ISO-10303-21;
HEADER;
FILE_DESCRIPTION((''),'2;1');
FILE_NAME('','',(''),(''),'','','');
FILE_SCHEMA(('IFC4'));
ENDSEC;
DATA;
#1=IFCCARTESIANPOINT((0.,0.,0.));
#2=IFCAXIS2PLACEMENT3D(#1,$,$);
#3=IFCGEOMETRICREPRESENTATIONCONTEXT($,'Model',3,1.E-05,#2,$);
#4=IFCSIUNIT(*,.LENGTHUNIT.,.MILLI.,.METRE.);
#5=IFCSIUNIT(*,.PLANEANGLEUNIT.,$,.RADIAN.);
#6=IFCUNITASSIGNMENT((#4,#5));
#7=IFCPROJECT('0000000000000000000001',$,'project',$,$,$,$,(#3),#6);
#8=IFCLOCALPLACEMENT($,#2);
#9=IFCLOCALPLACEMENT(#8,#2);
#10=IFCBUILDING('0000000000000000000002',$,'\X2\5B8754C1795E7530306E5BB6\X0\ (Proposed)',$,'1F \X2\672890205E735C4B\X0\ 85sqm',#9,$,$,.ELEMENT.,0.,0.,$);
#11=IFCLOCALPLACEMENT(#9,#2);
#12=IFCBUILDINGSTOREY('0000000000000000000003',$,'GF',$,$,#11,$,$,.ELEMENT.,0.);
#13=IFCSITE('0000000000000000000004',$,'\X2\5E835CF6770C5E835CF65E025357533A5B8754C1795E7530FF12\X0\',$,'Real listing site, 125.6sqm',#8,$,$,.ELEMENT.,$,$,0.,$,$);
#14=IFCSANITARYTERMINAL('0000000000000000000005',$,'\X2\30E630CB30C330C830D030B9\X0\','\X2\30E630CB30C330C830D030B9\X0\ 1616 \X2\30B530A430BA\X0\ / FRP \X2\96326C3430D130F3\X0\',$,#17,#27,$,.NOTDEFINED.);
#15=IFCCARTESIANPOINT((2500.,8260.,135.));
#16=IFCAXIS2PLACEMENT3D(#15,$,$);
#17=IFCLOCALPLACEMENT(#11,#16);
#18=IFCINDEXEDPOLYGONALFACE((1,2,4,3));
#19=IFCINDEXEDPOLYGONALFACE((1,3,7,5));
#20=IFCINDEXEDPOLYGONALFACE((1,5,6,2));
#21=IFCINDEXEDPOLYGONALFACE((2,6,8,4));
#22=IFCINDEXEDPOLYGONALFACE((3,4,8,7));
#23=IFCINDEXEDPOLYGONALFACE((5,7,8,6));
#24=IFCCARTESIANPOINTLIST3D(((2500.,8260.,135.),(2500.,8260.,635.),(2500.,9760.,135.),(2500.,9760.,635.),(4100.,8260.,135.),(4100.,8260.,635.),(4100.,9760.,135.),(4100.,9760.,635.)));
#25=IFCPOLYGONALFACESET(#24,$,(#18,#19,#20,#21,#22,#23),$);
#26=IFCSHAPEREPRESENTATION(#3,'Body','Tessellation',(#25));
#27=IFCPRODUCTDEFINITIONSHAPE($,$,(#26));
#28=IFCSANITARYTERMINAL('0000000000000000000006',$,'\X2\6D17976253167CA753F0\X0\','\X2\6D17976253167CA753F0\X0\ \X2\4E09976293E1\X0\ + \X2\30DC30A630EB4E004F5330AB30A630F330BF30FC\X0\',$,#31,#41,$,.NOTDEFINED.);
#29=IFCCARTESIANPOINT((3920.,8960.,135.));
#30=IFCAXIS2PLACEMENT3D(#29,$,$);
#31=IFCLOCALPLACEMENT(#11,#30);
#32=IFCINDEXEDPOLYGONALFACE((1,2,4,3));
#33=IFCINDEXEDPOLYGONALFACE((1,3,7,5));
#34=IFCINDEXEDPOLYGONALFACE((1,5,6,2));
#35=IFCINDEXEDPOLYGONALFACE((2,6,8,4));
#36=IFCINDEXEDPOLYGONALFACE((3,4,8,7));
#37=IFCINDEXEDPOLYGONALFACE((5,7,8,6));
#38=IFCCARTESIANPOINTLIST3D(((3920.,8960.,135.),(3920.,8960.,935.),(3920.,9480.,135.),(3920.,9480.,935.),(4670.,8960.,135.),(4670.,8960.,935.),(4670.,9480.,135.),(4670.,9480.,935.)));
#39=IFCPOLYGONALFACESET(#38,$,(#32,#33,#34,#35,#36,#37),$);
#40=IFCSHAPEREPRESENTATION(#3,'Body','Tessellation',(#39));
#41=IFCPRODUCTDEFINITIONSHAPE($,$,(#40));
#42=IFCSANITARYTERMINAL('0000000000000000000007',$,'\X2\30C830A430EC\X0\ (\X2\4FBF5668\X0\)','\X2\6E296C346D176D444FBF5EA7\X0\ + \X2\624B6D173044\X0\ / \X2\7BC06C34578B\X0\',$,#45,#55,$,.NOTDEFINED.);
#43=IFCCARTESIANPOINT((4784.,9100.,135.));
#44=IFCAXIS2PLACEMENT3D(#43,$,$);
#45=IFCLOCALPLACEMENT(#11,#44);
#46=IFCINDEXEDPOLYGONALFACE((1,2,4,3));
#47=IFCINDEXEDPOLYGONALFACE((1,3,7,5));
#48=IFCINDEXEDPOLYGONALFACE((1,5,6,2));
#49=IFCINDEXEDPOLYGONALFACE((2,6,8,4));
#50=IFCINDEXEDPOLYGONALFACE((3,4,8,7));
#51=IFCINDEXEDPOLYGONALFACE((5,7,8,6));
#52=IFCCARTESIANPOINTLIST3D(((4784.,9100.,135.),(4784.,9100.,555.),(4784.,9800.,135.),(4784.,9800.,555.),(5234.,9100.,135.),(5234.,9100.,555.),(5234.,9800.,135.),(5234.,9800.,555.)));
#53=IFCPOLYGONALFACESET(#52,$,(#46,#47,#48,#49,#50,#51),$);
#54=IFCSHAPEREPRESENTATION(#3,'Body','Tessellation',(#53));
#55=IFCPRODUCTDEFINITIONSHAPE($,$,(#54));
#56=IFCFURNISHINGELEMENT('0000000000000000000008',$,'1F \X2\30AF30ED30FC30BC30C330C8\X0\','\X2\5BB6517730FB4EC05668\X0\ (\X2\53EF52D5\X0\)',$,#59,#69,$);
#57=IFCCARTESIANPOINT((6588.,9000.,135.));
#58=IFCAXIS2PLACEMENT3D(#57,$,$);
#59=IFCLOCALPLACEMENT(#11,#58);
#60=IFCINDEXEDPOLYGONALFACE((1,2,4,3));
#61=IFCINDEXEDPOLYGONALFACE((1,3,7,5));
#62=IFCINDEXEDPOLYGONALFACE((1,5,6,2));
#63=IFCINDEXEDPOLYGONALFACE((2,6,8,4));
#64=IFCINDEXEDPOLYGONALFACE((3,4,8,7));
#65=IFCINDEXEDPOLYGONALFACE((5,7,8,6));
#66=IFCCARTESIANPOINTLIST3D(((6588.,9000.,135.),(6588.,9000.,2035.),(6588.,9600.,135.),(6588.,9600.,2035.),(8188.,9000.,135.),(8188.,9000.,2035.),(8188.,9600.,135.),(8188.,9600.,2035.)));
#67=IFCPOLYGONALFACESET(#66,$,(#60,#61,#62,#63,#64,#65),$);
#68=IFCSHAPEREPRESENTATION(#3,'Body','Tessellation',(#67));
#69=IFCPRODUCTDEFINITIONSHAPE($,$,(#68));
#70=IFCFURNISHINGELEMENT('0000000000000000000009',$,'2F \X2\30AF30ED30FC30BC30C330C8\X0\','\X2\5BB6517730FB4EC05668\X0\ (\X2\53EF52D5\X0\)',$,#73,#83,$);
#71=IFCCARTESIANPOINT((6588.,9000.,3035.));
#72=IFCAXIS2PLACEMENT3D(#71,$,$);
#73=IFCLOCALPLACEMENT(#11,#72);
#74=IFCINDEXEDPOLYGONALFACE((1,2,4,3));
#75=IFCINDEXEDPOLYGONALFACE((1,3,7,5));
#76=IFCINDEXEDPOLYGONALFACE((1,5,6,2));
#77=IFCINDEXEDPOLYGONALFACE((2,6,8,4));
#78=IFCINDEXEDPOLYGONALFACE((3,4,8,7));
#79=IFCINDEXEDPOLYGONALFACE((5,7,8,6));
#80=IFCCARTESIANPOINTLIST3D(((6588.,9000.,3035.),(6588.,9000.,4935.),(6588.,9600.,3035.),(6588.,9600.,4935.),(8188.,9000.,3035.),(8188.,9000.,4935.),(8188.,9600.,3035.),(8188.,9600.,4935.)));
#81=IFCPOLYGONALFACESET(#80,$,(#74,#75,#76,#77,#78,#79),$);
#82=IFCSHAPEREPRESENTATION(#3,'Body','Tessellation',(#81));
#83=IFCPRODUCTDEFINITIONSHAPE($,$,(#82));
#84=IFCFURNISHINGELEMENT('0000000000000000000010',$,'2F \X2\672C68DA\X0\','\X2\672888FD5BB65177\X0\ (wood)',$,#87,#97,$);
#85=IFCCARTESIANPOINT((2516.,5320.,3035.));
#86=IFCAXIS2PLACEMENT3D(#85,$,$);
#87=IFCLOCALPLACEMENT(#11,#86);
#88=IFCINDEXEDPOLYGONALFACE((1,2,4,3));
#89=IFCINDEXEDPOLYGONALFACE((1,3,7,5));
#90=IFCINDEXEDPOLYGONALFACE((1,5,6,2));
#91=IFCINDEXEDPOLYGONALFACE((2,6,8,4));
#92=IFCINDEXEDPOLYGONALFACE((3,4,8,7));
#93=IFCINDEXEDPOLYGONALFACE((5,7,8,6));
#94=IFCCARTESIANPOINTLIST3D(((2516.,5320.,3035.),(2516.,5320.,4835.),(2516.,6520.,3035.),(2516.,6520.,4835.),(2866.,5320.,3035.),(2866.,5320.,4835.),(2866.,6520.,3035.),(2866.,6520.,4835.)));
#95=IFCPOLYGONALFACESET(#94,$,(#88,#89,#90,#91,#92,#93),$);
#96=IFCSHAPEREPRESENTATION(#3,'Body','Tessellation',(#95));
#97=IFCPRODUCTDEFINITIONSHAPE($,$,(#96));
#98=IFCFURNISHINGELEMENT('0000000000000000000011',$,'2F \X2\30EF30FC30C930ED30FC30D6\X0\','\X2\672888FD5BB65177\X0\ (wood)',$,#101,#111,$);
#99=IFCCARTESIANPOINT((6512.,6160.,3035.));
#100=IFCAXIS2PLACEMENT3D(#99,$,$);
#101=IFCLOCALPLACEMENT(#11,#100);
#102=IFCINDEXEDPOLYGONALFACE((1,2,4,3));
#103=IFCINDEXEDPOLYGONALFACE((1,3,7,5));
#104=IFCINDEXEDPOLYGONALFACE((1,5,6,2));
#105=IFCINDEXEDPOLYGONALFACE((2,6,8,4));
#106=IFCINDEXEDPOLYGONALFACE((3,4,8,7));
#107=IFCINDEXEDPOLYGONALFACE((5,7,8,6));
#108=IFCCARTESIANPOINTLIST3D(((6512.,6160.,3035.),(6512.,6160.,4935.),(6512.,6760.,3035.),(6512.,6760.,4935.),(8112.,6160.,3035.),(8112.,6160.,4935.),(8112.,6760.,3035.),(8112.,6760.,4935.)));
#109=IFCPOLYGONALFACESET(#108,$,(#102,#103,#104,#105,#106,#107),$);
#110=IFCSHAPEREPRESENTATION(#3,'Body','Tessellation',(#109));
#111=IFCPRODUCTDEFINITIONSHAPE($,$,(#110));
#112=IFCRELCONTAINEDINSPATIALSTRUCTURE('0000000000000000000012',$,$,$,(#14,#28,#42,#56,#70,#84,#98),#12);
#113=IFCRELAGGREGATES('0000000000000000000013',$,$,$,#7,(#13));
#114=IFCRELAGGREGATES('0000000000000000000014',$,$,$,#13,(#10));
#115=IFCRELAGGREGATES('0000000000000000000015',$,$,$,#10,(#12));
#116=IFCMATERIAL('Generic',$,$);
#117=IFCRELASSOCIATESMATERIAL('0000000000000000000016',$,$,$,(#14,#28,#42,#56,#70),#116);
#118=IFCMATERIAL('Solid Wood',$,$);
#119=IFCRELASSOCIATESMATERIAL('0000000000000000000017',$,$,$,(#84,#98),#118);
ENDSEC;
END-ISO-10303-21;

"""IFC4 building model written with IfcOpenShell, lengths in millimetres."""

from ifc_helpers import new_model, si_unit, frame, frame_2d, origin, place, context, project, spatial, rectangle, extrude, material, element, save


model = new_model("IFC4")

# Units and contexts
model_context = context("Model", 3, precision=1e-05, world=origin())
ifc_project = project(units=[si_unit("LENGTHUNIT", "METRE", prefix="MILLI"), si_unit("PLANEANGLEUNIT", "RADIAN")], contexts=[model_context])

# Site, building, storey
site_placement = place(None, origin())
site = spatial("IfcSite", under=ifc_project, at=site_placement, Name="広島県広島市南区宇品神田２", ObjectType="Real listing site, 125.6sqm", CompositionType="ELEMENT", RefElevation=0.0)
building_placement = place(site_placement, origin())
building = spatial("IfcBuilding", under=site, at=building_placement, Name="宇品神田の家 (Proposed)", ObjectType="1F 木造平屋 85sqm", CompositionType="ELEMENT", ElevationOfRefHeight=0.0, ElevationOfTerrain=0.0)
storey_placement = place(building_placement, origin())
storey = spatial("IfcBuildingStorey", under=building, at=storey_placement, Name="GF", CompositionType="ELEMENT", Elevation=0.0)

# Shared definitions
ifc_material_1 = material(Name="Solid Wood")

# Shared definitions
ifc_material_2 = material(Name="Generic")

# Sanitary terminals
sanitary_terminal_1_placement = place(storey_placement, frame((2500.0, 8260.0, 135.0)))
element("IfcSanitaryTerminal", 1, at=sanitary_terminal_1_placement, inside=storey, material=ifc_material_2, Name="ユニットバス", Description="ユニットバス 1616 サイズ / FRP 防水パン", PredefinedType="NOTDEFINED", context=model_context, shape_type="SweptSolid", body=[
    extrude(rectangle(XDim=1600.0, YDim=1500.0, at=frame_2d((800.0, 750.0))), frame((2500.0, 8260.0, 135.0)), (0.0, 0.0, 1.0), 500.0),
])
sanitary_terminal_2_placement = place(storey_placement, frame((3920.0, 8960.0, 135.0)))
element("IfcSanitaryTerminal", 2, at=sanitary_terminal_2_placement, inside=storey, material=ifc_material_2, Name="洗面化粧台", Description="洗面化粧台 三面鏡 + ボウル一体カウンター", PredefinedType="NOTDEFINED", context=model_context, shape_type="SweptSolid", body=[
    extrude(rectangle(XDim=750.0, YDim=520.0, at=frame_2d((375.0, 260.0))), frame((3920.0, 8960.0, 135.0)), (0.0, 0.0, 1.0), 800.0),
])
sanitary_terminal_3_placement = place(storey_placement, frame((4784.0, 9100.0, 135.0)))
element("IfcSanitaryTerminal", 3, at=sanitary_terminal_3_placement, inside=storey, material=ifc_material_2, Name="トイレ (便器)", Description="温水洗浄便座 + 手洗い / 節水型", PredefinedType="NOTDEFINED", context=model_context, shape_type="SweptSolid", body=[
    extrude(rectangle(XDim=450.0, YDim=700.0, at=frame_2d((225.0, 350.0))), frame((4784.0, 9100.0, 135.0)), (0.0, 0.0, 1.0), 420.0),
])

# Furnishing elements
furnishing_1_placement = place(storey_placement, frame((6588.0, 9000.0, 135.0)))
element("IfcFurnishingElement", 4, at=furnishing_1_placement, inside=storey, material=ifc_material_2, Name="1F クローゼット", Description="家具・什器 (可動)", context=model_context, shape_type="SweptSolid", body=[
    extrude(rectangle(XDim=1600.0, YDim=600.0, at=frame_2d((800.0, 300.0))), frame((6588.0, 9000.0, 135.0)), (0.0, 0.0, 1.0), 1900.0),
])
furnishing_2_placement = place(storey_placement, frame((6588.0, 9000.0, 3035.0)))
element("IfcFurnishingElement", 5, at=furnishing_2_placement, inside=storey, material=ifc_material_2, Name="2F クローゼット", Description="家具・什器 (可動)", context=model_context, shape_type="SweptSolid", body=[
    extrude(rectangle(XDim=1600.0, YDim=600.0, at=frame_2d((800.0, 300.0))), frame((6588.0, 9000.0, 3035.0)), (0.0, 0.0, 1.0), 1900.0),
])
furnishing_3_placement = place(storey_placement, frame((2516.0, 5320.0, 3035.0)))
element("IfcFurnishingElement", 6, at=furnishing_3_placement, inside=storey, material=ifc_material_1, Name="2F 本棚", Description="木製家具 (wood)", context=model_context, shape_type="SweptSolid", body=[
    extrude(rectangle(XDim=350.0, YDim=1200.0, at=frame_2d((175.0, 600.0))), frame((2516.0, 5320.0, 3035.0)), (0.0, 0.0, 1.0), 1800.0),
])
furnishing_4_placement = place(storey_placement, frame((6512.0, 6160.0, 3035.0)))
element("IfcFurnishingElement", 7, at=furnishing_4_placement, inside=storey, material=ifc_material_1, Name="2F ワードローブ", Description="木製家具 (wood)", context=model_context, shape_type="SweptSolid", body=[
    extrude(rectangle(XDim=1600.0, YDim=600.0, at=frame_2d((800.0, 300.0))), frame((6512.0, 6160.0, 3035.0)), (0.0, 0.0, 1.0), 1900.0),
])

save(model, "model.ifc")
